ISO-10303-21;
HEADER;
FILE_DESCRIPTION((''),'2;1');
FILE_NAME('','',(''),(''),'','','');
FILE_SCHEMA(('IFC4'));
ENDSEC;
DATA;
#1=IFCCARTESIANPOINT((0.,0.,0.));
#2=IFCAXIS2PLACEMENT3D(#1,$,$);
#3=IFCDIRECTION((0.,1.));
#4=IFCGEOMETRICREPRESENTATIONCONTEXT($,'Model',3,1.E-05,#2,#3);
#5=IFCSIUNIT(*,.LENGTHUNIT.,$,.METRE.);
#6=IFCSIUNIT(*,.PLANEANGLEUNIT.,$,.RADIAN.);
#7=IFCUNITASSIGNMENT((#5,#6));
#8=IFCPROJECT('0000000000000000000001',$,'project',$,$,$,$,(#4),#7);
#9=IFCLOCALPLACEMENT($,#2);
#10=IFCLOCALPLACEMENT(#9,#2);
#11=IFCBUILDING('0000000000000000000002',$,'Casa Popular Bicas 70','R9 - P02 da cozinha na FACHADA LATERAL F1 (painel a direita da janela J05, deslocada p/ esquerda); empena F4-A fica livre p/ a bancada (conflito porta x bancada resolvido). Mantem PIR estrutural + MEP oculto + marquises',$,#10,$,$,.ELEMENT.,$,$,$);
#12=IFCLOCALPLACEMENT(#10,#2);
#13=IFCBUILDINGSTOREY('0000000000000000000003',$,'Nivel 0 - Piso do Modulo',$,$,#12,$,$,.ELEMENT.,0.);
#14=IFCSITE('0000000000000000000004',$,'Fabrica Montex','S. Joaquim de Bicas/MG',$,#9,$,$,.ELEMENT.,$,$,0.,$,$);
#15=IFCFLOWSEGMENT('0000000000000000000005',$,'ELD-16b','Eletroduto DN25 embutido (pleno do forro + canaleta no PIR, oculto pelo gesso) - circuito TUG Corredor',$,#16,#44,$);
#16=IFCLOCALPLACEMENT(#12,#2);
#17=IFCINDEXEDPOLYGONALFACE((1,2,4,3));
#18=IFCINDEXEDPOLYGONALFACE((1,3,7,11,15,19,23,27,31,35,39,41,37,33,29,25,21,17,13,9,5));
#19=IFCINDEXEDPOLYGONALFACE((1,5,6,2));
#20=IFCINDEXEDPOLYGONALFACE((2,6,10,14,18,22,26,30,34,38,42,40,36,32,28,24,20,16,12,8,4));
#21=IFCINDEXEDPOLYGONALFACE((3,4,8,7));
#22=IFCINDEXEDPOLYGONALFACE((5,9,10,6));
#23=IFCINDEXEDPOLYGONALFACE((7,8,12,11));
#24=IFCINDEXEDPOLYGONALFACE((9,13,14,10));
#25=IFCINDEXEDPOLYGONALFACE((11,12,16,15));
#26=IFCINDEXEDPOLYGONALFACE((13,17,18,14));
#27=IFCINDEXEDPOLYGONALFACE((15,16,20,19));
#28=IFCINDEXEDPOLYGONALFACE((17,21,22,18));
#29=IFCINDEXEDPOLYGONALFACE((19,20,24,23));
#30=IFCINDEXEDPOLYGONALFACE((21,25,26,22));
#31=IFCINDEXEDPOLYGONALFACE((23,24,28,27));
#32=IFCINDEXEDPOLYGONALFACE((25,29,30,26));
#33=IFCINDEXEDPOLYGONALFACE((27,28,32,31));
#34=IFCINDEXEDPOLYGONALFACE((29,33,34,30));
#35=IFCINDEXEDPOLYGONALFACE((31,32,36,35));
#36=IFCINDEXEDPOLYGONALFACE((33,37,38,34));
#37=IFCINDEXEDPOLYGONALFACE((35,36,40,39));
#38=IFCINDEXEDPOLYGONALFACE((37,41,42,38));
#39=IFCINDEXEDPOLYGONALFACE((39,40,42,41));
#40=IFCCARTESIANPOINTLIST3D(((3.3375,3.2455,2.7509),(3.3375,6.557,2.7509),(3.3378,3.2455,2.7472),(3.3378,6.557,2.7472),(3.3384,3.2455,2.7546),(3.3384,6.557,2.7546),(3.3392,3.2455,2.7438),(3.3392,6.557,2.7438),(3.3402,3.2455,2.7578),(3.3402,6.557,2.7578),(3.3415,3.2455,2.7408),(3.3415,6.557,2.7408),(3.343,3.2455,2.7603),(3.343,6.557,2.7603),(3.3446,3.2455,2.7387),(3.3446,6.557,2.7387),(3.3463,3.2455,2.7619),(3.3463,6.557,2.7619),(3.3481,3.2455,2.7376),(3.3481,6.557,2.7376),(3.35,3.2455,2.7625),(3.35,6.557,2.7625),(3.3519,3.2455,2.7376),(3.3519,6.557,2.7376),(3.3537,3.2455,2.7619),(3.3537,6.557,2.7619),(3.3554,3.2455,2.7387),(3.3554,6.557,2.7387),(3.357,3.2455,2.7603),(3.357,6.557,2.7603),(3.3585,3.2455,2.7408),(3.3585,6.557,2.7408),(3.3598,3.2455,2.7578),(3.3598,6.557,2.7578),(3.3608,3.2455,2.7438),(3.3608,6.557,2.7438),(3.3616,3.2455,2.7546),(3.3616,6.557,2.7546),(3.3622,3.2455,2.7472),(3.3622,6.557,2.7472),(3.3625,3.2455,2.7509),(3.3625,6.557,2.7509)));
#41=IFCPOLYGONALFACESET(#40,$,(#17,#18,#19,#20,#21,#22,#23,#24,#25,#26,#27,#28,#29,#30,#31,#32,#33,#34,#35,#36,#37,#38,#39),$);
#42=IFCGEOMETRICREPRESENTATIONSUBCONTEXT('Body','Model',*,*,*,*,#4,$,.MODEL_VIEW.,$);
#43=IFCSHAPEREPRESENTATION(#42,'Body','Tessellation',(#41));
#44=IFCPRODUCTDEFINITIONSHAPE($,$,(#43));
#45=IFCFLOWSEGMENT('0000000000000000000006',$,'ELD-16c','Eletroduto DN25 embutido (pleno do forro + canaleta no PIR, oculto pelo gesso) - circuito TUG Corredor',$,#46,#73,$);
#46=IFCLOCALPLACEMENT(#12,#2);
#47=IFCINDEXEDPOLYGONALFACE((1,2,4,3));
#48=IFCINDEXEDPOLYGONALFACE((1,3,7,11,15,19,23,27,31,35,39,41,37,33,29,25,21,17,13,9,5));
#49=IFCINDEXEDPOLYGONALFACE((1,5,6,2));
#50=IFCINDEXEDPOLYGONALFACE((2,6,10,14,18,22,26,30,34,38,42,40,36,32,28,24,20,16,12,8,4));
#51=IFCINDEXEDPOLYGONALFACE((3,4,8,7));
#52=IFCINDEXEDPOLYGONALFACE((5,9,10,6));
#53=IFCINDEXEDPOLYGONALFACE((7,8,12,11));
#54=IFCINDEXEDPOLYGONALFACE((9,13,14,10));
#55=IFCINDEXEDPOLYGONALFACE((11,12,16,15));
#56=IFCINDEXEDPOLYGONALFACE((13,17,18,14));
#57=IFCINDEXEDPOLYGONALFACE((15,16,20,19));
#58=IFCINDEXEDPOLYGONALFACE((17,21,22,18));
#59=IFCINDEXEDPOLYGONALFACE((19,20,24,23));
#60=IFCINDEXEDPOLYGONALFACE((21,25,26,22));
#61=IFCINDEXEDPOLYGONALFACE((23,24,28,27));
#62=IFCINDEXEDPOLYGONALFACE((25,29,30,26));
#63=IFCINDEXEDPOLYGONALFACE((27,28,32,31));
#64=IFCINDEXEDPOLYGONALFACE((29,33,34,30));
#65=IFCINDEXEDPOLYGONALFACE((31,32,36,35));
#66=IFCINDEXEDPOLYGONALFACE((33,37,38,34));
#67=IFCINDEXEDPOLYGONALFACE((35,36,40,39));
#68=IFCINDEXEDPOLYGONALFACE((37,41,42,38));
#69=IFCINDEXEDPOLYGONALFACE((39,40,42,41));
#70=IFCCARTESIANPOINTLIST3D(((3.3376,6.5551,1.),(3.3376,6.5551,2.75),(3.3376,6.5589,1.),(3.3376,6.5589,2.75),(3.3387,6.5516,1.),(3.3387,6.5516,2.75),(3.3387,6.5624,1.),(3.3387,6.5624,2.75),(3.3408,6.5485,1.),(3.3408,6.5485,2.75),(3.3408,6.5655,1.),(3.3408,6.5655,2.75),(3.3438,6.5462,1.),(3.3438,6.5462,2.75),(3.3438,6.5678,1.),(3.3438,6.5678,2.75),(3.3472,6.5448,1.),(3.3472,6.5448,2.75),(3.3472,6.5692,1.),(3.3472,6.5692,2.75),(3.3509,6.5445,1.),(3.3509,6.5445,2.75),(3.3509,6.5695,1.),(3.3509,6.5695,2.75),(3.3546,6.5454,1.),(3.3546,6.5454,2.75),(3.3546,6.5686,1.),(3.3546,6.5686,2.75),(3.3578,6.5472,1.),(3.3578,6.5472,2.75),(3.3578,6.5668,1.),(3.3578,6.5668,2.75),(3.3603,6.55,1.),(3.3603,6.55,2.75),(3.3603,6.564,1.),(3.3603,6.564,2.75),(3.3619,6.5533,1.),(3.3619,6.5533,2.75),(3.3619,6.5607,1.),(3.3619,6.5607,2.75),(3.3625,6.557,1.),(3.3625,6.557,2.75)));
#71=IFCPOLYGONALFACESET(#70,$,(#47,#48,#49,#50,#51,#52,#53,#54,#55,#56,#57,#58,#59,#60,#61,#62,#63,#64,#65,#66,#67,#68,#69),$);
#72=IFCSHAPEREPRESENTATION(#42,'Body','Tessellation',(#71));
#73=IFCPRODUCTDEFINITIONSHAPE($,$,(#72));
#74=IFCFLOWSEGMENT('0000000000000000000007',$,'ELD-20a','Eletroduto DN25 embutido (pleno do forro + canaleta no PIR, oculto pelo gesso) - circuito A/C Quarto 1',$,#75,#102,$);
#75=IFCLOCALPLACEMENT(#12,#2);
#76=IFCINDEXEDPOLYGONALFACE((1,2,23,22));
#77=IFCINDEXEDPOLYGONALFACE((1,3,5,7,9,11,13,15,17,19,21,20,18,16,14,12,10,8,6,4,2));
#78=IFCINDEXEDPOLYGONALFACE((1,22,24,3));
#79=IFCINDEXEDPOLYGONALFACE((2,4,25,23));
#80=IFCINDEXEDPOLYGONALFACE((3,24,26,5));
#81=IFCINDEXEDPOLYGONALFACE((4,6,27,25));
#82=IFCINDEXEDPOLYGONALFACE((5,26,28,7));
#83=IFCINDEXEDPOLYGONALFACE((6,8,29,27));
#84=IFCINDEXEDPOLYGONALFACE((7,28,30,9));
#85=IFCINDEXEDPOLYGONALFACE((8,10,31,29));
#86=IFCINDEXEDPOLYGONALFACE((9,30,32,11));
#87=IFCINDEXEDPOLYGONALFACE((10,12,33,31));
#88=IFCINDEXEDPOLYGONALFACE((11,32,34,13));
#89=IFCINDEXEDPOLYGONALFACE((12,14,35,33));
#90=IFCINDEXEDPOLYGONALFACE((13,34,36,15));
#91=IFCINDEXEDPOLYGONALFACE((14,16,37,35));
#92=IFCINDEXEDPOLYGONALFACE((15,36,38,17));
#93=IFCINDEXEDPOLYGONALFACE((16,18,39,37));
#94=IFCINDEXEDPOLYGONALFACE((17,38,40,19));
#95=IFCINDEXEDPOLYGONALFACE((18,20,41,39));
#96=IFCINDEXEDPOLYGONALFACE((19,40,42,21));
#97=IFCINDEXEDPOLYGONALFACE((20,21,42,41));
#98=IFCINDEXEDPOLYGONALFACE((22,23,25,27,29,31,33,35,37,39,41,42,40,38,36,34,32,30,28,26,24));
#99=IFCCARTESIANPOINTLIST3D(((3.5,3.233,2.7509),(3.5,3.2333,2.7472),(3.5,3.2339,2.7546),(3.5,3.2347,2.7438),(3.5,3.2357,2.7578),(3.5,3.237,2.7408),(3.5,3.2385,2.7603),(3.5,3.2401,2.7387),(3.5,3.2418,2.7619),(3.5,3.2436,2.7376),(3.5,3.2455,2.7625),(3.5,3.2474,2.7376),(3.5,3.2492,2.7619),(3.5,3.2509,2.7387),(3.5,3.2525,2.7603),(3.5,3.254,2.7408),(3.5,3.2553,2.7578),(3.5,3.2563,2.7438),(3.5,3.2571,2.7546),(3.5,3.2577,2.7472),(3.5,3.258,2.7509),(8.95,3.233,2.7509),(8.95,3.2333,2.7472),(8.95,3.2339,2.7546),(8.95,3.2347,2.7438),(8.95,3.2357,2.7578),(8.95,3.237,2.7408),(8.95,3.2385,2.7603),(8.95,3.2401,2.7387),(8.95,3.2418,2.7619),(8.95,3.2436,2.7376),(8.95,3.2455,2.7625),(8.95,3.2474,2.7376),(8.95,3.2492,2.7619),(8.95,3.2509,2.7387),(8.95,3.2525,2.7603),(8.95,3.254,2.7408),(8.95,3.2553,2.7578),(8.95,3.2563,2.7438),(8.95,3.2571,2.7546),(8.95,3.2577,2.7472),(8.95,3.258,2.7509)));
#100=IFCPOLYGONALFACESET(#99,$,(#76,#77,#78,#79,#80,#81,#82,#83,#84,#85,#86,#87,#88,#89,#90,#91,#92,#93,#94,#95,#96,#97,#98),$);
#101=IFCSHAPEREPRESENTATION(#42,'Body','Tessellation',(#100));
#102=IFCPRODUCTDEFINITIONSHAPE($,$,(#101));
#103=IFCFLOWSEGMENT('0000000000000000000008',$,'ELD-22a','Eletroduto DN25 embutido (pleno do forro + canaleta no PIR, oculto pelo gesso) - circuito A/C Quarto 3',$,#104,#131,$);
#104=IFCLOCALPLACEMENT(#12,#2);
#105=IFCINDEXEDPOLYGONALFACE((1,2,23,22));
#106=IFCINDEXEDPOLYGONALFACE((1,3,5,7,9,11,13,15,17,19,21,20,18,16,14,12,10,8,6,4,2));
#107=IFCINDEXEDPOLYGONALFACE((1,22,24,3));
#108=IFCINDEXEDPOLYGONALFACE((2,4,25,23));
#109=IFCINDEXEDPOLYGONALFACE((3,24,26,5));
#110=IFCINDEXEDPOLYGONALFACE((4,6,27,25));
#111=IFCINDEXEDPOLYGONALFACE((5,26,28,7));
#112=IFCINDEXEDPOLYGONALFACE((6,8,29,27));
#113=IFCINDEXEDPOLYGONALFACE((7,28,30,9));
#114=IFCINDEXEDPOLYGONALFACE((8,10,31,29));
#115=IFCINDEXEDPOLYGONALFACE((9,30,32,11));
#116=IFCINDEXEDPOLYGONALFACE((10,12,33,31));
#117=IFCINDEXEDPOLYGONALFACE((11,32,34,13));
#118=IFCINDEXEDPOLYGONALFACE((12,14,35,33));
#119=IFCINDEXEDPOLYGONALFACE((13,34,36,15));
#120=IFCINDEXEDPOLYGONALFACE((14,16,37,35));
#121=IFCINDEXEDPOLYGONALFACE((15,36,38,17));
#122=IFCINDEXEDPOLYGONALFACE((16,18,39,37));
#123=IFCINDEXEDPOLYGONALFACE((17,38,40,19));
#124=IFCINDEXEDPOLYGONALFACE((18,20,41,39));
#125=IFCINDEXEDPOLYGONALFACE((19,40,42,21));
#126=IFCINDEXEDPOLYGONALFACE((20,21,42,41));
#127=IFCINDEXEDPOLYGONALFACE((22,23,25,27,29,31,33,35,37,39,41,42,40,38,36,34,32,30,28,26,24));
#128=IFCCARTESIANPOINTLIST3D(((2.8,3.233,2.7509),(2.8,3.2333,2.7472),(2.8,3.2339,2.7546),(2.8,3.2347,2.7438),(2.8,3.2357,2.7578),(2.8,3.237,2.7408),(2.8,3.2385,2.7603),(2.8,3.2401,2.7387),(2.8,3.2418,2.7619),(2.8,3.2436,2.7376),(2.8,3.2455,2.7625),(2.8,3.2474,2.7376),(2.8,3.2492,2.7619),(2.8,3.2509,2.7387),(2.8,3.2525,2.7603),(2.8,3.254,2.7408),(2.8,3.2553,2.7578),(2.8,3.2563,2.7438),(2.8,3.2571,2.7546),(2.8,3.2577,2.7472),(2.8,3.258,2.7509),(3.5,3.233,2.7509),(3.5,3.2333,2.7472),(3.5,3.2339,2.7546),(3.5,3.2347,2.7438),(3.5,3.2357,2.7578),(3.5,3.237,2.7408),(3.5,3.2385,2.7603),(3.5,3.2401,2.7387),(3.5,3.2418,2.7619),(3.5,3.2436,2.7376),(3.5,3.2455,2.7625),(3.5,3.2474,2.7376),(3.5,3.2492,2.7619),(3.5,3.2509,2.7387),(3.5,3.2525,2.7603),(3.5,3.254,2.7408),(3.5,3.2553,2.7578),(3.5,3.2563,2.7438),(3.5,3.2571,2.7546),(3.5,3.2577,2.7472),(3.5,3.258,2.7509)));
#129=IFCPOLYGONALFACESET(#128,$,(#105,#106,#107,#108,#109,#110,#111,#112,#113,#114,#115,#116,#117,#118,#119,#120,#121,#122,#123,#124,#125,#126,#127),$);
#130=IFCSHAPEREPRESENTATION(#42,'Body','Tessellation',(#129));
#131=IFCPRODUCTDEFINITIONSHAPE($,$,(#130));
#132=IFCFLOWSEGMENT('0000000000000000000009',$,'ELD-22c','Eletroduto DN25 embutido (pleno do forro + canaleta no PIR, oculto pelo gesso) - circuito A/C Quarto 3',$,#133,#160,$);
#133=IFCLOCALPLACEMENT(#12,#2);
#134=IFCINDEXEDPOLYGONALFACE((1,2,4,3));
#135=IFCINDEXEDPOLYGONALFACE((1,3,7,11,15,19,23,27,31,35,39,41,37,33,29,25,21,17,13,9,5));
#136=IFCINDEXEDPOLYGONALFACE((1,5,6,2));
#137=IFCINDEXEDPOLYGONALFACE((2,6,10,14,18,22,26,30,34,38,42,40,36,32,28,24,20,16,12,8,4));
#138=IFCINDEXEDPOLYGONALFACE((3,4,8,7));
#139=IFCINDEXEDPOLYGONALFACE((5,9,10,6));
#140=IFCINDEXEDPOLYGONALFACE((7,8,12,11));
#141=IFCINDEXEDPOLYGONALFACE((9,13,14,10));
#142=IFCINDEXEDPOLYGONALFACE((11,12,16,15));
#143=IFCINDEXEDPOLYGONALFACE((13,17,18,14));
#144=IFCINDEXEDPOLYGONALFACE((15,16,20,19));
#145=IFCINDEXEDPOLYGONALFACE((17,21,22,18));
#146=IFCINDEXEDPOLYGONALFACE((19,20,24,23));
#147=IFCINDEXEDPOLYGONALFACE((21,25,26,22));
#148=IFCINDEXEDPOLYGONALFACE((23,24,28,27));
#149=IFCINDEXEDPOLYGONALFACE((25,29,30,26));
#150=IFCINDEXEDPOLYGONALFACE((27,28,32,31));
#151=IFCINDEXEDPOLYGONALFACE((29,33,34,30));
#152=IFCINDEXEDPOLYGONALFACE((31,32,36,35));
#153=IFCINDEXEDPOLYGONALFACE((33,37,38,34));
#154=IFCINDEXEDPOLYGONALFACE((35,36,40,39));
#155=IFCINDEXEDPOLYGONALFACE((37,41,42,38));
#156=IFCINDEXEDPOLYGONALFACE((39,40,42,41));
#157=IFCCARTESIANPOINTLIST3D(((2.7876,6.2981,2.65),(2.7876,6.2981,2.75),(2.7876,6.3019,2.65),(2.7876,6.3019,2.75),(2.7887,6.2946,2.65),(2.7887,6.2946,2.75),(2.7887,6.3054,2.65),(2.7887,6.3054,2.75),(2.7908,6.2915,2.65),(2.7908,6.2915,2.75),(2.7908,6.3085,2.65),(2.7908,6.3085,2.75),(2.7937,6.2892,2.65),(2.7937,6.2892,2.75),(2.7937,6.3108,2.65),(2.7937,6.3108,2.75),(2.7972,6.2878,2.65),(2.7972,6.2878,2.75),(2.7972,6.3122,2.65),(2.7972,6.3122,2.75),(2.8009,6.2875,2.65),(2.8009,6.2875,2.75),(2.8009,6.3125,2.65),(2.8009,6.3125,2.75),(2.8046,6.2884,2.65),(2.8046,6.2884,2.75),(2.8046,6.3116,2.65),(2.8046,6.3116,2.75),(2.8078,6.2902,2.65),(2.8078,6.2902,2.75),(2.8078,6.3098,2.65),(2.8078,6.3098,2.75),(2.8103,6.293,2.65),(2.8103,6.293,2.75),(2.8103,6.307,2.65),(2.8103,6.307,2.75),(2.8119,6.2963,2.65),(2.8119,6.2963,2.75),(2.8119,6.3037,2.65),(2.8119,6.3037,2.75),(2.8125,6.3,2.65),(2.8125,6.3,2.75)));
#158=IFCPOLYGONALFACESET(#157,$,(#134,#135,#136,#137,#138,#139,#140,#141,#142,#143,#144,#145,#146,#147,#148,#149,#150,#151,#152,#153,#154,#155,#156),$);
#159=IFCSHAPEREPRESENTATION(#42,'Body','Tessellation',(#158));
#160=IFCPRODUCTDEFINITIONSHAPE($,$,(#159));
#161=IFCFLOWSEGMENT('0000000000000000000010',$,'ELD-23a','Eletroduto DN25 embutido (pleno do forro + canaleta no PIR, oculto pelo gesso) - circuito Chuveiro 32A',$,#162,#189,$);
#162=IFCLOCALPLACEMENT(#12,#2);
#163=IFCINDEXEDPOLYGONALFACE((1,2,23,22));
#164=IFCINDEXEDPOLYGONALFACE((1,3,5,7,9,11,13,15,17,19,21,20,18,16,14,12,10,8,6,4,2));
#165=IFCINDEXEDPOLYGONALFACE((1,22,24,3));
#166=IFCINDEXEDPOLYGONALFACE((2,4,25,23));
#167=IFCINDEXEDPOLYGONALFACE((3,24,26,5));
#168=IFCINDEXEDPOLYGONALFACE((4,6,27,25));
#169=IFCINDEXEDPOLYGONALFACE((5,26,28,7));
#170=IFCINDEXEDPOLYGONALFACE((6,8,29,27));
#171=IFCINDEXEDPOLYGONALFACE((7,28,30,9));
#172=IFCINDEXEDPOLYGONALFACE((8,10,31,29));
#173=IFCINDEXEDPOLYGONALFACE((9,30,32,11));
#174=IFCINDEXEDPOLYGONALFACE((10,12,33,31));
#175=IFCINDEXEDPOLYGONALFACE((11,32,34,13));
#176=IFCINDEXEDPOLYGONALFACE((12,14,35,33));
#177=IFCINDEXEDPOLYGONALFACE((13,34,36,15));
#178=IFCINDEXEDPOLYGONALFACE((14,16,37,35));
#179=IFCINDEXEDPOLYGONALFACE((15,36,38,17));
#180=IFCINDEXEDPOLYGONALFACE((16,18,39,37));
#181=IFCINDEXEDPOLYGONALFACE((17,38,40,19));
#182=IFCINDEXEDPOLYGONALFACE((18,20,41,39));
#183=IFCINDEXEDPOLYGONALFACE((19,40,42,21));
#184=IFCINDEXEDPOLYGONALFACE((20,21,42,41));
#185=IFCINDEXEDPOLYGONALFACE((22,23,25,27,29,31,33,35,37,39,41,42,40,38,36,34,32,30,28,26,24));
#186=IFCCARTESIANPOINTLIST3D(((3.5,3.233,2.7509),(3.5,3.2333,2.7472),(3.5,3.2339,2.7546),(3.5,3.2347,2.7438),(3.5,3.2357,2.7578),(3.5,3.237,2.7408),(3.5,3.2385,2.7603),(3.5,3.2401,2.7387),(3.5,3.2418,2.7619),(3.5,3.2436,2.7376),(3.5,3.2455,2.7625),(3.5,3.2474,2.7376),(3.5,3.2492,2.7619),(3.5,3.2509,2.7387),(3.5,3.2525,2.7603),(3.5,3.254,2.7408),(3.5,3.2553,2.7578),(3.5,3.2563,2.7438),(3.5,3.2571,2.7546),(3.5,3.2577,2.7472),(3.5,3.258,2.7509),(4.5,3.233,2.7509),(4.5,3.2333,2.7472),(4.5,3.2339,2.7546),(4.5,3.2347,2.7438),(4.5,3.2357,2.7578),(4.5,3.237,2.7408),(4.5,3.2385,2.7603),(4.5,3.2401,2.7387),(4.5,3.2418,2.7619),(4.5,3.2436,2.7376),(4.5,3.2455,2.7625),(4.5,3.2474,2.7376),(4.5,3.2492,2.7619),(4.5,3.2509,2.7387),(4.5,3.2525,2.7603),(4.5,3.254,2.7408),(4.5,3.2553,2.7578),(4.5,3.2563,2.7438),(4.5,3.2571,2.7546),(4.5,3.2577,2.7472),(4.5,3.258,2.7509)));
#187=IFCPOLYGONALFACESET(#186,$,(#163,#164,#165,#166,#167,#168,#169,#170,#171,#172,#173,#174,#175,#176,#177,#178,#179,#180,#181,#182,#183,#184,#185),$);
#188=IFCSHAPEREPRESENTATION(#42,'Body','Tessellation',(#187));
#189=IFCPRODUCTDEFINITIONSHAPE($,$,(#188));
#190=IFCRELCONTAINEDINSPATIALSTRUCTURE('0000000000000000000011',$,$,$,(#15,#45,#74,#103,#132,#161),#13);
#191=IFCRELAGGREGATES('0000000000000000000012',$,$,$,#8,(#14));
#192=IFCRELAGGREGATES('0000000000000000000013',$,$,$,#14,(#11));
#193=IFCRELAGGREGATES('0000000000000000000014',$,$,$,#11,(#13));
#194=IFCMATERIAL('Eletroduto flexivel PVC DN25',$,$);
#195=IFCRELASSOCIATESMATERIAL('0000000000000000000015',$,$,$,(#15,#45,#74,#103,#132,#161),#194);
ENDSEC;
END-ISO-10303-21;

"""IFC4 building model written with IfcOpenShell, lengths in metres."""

from ifc_helpers import new_model, si_unit, direction, frame, origin, origin_2d, place, context, subcontext, project, spatial, circle, extrude, material, element, save


model = new_model("IFC4")

# Units and contexts
model_context = context("Model", 3, precision=1e-05, world=origin(), true_north=direction((0.0, 1.0)))
body_context = subcontext(model_context, "Body", "Model", "MODEL_VIEW")
ifc_project = project(units=[si_unit("LENGTHUNIT", "METRE"), si_unit("PLANEANGLEUNIT", "RADIAN")], contexts=[model_context])

# Site, building, storey
site_placement = place(None, origin())
site = spatial("IfcSite", under=ifc_project, at=site_placement, Name="Fabrica Montex", Description="S. Joaquim de Bicas/MG", CompositionType="ELEMENT", RefElevation=0.0)
building_placement = place(site_placement, origin())
building = spatial("IfcBuilding", under=site, at=building_placement, Name="Casa Popular Bicas 70", Description="R9 - P02 da cozinha na FACHADA LATERAL F1 (painel a direita da janela J05, deslocada p/ esquerda); empena F4-A fica livre p/ a bancada (conflito porta x bancada resolvido). Mantem PIR estrutural + MEP oculto + marquises", CompositionType="ELEMENT")
storey_placement = place(building_placement, origin())
storey = spatial("IfcBuildingStorey", under=building, at=storey_placement, Name="Nivel 0 - Piso do Modulo", CompositionType="ELEMENT", Elevation=0.0)

# Flow segments
ifc_material_1 = material(Name="Eletroduto flexivel PVC DN25")
flow_segment_1_placement = place(storey_placement, frame((3.35, 3.2455, 2.75), z_axis=(0.0, 1.0, 0.0), x_axis=(0.0, 0.0, 1.0)))
element("IfcFlowSegment", 1, at=flow_segment_1_placement, inside=storey, material=ifc_material_1, Name="ELD-16b", Description="Eletroduto DN25 embutido (pleno do forro + canaleta no PIR, oculto pelo gesso) - circuito TUG Corredor", context=body_context, shape_type="SweptSolid", body=[
    extrude(circle(Radius=0.0125, at=origin_2d()), origin(), (0.0, 0.0, 1.0), 3.3115),
])
flow_segment_2_placement = place(storey_placement, frame((3.35, 6.557, 2.75), z_axis=(0.0, 0.0, -1.0), x_axis=(1.0, 0.0, 0.0)))
element("IfcFlowSegment", 2, at=flow_segment_2_placement, inside=storey, material=ifc_material_1, Name="ELD-16c", Description="Eletroduto DN25 embutido (pleno do forro + canaleta no PIR, oculto pelo gesso) - circuito TUG Corredor", context=body_context, shape_type="SweptSolid", body=[
    extrude(circle(Radius=0.0125, at=origin_2d()), origin(), (0.0, 0.0, 1.0), 1.75),
])
flow_segment_3_placement = place(storey_placement, frame((3.5, 3.2455, 2.75), z_axis=(1.0, 0.0, 0.0), x_axis=(0.0, 0.0, 1.0)))
element("IfcFlowSegment", 3, at=flow_segment_3_placement, inside=storey, material=ifc_material_1, Name="ELD-20a", Description="Eletroduto DN25 embutido (pleno do forro + canaleta no PIR, oculto pelo gesso) - circuito A/C Quarto 1", context=body_context, shape_type="SweptSolid", body=[
    extrude(circle(Radius=0.0125, at=origin_2d()), origin(), (0.0, 0.0, 1.0), 5.45),
])
flow_segment_4_placement = place(storey_placement, frame((3.5, 3.2455, 2.75), z_axis=(-1.0, 0.0, 0.0), x_axis=(0.0, 0.0, 1.0)))
element("IfcFlowSegment", 4, at=flow_segment_4_placement, inside=storey, material=ifc_material_1, Name="ELD-22a", Description="Eletroduto DN25 embutido (pleno do forro + canaleta no PIR, oculto pelo gesso) - circuito A/C Quarto 3", context=body_context, shape_type="SweptSolid", body=[
    extrude(circle(Radius=0.0125, at=origin_2d()), origin(), (0.0, 0.0, 1.0), 0.7),
])
flow_segment_5_placement = place(storey_placement, frame((2.8, 6.3, 2.75), z_axis=(0.0, 0.0, -1.0), x_axis=(1.0, 0.0, 0.0)))
element("IfcFlowSegment", 5, at=flow_segment_5_placement, inside=storey, material=ifc_material_1, Name="ELD-22c", Description="Eletroduto DN25 embutido (pleno do forro + canaleta no PIR, oculto pelo gesso) - circuito A/C Quarto 3", context=body_context, shape_type="SweptSolid", body=[
    extrude(circle(Radius=0.0125, at=origin_2d()), origin(), (0.0, 0.0, 1.0), 0.1),
])
flow_segment_6_placement = place(storey_placement, frame((3.5, 3.2455, 2.75), z_axis=(1.0, 0.0, 0.0), x_axis=(0.0, 0.0, 1.0)))
element("IfcFlowSegment", 6, at=flow_segment_6_placement, inside=storey, material=ifc_material_1, Name="ELD-23a", Description="Eletroduto DN25 embutido (pleno do forro + canaleta no PIR, oculto pelo gesso) - circuito Chuveiro 32A", context=body_context, shape_type="SweptSolid", body=[
    extrude(circle(Radius=0.0125, at=origin_2d()), origin(), (0.0, 0.0, 1.0), 1.0),
])

save(model, "model.ifc")
